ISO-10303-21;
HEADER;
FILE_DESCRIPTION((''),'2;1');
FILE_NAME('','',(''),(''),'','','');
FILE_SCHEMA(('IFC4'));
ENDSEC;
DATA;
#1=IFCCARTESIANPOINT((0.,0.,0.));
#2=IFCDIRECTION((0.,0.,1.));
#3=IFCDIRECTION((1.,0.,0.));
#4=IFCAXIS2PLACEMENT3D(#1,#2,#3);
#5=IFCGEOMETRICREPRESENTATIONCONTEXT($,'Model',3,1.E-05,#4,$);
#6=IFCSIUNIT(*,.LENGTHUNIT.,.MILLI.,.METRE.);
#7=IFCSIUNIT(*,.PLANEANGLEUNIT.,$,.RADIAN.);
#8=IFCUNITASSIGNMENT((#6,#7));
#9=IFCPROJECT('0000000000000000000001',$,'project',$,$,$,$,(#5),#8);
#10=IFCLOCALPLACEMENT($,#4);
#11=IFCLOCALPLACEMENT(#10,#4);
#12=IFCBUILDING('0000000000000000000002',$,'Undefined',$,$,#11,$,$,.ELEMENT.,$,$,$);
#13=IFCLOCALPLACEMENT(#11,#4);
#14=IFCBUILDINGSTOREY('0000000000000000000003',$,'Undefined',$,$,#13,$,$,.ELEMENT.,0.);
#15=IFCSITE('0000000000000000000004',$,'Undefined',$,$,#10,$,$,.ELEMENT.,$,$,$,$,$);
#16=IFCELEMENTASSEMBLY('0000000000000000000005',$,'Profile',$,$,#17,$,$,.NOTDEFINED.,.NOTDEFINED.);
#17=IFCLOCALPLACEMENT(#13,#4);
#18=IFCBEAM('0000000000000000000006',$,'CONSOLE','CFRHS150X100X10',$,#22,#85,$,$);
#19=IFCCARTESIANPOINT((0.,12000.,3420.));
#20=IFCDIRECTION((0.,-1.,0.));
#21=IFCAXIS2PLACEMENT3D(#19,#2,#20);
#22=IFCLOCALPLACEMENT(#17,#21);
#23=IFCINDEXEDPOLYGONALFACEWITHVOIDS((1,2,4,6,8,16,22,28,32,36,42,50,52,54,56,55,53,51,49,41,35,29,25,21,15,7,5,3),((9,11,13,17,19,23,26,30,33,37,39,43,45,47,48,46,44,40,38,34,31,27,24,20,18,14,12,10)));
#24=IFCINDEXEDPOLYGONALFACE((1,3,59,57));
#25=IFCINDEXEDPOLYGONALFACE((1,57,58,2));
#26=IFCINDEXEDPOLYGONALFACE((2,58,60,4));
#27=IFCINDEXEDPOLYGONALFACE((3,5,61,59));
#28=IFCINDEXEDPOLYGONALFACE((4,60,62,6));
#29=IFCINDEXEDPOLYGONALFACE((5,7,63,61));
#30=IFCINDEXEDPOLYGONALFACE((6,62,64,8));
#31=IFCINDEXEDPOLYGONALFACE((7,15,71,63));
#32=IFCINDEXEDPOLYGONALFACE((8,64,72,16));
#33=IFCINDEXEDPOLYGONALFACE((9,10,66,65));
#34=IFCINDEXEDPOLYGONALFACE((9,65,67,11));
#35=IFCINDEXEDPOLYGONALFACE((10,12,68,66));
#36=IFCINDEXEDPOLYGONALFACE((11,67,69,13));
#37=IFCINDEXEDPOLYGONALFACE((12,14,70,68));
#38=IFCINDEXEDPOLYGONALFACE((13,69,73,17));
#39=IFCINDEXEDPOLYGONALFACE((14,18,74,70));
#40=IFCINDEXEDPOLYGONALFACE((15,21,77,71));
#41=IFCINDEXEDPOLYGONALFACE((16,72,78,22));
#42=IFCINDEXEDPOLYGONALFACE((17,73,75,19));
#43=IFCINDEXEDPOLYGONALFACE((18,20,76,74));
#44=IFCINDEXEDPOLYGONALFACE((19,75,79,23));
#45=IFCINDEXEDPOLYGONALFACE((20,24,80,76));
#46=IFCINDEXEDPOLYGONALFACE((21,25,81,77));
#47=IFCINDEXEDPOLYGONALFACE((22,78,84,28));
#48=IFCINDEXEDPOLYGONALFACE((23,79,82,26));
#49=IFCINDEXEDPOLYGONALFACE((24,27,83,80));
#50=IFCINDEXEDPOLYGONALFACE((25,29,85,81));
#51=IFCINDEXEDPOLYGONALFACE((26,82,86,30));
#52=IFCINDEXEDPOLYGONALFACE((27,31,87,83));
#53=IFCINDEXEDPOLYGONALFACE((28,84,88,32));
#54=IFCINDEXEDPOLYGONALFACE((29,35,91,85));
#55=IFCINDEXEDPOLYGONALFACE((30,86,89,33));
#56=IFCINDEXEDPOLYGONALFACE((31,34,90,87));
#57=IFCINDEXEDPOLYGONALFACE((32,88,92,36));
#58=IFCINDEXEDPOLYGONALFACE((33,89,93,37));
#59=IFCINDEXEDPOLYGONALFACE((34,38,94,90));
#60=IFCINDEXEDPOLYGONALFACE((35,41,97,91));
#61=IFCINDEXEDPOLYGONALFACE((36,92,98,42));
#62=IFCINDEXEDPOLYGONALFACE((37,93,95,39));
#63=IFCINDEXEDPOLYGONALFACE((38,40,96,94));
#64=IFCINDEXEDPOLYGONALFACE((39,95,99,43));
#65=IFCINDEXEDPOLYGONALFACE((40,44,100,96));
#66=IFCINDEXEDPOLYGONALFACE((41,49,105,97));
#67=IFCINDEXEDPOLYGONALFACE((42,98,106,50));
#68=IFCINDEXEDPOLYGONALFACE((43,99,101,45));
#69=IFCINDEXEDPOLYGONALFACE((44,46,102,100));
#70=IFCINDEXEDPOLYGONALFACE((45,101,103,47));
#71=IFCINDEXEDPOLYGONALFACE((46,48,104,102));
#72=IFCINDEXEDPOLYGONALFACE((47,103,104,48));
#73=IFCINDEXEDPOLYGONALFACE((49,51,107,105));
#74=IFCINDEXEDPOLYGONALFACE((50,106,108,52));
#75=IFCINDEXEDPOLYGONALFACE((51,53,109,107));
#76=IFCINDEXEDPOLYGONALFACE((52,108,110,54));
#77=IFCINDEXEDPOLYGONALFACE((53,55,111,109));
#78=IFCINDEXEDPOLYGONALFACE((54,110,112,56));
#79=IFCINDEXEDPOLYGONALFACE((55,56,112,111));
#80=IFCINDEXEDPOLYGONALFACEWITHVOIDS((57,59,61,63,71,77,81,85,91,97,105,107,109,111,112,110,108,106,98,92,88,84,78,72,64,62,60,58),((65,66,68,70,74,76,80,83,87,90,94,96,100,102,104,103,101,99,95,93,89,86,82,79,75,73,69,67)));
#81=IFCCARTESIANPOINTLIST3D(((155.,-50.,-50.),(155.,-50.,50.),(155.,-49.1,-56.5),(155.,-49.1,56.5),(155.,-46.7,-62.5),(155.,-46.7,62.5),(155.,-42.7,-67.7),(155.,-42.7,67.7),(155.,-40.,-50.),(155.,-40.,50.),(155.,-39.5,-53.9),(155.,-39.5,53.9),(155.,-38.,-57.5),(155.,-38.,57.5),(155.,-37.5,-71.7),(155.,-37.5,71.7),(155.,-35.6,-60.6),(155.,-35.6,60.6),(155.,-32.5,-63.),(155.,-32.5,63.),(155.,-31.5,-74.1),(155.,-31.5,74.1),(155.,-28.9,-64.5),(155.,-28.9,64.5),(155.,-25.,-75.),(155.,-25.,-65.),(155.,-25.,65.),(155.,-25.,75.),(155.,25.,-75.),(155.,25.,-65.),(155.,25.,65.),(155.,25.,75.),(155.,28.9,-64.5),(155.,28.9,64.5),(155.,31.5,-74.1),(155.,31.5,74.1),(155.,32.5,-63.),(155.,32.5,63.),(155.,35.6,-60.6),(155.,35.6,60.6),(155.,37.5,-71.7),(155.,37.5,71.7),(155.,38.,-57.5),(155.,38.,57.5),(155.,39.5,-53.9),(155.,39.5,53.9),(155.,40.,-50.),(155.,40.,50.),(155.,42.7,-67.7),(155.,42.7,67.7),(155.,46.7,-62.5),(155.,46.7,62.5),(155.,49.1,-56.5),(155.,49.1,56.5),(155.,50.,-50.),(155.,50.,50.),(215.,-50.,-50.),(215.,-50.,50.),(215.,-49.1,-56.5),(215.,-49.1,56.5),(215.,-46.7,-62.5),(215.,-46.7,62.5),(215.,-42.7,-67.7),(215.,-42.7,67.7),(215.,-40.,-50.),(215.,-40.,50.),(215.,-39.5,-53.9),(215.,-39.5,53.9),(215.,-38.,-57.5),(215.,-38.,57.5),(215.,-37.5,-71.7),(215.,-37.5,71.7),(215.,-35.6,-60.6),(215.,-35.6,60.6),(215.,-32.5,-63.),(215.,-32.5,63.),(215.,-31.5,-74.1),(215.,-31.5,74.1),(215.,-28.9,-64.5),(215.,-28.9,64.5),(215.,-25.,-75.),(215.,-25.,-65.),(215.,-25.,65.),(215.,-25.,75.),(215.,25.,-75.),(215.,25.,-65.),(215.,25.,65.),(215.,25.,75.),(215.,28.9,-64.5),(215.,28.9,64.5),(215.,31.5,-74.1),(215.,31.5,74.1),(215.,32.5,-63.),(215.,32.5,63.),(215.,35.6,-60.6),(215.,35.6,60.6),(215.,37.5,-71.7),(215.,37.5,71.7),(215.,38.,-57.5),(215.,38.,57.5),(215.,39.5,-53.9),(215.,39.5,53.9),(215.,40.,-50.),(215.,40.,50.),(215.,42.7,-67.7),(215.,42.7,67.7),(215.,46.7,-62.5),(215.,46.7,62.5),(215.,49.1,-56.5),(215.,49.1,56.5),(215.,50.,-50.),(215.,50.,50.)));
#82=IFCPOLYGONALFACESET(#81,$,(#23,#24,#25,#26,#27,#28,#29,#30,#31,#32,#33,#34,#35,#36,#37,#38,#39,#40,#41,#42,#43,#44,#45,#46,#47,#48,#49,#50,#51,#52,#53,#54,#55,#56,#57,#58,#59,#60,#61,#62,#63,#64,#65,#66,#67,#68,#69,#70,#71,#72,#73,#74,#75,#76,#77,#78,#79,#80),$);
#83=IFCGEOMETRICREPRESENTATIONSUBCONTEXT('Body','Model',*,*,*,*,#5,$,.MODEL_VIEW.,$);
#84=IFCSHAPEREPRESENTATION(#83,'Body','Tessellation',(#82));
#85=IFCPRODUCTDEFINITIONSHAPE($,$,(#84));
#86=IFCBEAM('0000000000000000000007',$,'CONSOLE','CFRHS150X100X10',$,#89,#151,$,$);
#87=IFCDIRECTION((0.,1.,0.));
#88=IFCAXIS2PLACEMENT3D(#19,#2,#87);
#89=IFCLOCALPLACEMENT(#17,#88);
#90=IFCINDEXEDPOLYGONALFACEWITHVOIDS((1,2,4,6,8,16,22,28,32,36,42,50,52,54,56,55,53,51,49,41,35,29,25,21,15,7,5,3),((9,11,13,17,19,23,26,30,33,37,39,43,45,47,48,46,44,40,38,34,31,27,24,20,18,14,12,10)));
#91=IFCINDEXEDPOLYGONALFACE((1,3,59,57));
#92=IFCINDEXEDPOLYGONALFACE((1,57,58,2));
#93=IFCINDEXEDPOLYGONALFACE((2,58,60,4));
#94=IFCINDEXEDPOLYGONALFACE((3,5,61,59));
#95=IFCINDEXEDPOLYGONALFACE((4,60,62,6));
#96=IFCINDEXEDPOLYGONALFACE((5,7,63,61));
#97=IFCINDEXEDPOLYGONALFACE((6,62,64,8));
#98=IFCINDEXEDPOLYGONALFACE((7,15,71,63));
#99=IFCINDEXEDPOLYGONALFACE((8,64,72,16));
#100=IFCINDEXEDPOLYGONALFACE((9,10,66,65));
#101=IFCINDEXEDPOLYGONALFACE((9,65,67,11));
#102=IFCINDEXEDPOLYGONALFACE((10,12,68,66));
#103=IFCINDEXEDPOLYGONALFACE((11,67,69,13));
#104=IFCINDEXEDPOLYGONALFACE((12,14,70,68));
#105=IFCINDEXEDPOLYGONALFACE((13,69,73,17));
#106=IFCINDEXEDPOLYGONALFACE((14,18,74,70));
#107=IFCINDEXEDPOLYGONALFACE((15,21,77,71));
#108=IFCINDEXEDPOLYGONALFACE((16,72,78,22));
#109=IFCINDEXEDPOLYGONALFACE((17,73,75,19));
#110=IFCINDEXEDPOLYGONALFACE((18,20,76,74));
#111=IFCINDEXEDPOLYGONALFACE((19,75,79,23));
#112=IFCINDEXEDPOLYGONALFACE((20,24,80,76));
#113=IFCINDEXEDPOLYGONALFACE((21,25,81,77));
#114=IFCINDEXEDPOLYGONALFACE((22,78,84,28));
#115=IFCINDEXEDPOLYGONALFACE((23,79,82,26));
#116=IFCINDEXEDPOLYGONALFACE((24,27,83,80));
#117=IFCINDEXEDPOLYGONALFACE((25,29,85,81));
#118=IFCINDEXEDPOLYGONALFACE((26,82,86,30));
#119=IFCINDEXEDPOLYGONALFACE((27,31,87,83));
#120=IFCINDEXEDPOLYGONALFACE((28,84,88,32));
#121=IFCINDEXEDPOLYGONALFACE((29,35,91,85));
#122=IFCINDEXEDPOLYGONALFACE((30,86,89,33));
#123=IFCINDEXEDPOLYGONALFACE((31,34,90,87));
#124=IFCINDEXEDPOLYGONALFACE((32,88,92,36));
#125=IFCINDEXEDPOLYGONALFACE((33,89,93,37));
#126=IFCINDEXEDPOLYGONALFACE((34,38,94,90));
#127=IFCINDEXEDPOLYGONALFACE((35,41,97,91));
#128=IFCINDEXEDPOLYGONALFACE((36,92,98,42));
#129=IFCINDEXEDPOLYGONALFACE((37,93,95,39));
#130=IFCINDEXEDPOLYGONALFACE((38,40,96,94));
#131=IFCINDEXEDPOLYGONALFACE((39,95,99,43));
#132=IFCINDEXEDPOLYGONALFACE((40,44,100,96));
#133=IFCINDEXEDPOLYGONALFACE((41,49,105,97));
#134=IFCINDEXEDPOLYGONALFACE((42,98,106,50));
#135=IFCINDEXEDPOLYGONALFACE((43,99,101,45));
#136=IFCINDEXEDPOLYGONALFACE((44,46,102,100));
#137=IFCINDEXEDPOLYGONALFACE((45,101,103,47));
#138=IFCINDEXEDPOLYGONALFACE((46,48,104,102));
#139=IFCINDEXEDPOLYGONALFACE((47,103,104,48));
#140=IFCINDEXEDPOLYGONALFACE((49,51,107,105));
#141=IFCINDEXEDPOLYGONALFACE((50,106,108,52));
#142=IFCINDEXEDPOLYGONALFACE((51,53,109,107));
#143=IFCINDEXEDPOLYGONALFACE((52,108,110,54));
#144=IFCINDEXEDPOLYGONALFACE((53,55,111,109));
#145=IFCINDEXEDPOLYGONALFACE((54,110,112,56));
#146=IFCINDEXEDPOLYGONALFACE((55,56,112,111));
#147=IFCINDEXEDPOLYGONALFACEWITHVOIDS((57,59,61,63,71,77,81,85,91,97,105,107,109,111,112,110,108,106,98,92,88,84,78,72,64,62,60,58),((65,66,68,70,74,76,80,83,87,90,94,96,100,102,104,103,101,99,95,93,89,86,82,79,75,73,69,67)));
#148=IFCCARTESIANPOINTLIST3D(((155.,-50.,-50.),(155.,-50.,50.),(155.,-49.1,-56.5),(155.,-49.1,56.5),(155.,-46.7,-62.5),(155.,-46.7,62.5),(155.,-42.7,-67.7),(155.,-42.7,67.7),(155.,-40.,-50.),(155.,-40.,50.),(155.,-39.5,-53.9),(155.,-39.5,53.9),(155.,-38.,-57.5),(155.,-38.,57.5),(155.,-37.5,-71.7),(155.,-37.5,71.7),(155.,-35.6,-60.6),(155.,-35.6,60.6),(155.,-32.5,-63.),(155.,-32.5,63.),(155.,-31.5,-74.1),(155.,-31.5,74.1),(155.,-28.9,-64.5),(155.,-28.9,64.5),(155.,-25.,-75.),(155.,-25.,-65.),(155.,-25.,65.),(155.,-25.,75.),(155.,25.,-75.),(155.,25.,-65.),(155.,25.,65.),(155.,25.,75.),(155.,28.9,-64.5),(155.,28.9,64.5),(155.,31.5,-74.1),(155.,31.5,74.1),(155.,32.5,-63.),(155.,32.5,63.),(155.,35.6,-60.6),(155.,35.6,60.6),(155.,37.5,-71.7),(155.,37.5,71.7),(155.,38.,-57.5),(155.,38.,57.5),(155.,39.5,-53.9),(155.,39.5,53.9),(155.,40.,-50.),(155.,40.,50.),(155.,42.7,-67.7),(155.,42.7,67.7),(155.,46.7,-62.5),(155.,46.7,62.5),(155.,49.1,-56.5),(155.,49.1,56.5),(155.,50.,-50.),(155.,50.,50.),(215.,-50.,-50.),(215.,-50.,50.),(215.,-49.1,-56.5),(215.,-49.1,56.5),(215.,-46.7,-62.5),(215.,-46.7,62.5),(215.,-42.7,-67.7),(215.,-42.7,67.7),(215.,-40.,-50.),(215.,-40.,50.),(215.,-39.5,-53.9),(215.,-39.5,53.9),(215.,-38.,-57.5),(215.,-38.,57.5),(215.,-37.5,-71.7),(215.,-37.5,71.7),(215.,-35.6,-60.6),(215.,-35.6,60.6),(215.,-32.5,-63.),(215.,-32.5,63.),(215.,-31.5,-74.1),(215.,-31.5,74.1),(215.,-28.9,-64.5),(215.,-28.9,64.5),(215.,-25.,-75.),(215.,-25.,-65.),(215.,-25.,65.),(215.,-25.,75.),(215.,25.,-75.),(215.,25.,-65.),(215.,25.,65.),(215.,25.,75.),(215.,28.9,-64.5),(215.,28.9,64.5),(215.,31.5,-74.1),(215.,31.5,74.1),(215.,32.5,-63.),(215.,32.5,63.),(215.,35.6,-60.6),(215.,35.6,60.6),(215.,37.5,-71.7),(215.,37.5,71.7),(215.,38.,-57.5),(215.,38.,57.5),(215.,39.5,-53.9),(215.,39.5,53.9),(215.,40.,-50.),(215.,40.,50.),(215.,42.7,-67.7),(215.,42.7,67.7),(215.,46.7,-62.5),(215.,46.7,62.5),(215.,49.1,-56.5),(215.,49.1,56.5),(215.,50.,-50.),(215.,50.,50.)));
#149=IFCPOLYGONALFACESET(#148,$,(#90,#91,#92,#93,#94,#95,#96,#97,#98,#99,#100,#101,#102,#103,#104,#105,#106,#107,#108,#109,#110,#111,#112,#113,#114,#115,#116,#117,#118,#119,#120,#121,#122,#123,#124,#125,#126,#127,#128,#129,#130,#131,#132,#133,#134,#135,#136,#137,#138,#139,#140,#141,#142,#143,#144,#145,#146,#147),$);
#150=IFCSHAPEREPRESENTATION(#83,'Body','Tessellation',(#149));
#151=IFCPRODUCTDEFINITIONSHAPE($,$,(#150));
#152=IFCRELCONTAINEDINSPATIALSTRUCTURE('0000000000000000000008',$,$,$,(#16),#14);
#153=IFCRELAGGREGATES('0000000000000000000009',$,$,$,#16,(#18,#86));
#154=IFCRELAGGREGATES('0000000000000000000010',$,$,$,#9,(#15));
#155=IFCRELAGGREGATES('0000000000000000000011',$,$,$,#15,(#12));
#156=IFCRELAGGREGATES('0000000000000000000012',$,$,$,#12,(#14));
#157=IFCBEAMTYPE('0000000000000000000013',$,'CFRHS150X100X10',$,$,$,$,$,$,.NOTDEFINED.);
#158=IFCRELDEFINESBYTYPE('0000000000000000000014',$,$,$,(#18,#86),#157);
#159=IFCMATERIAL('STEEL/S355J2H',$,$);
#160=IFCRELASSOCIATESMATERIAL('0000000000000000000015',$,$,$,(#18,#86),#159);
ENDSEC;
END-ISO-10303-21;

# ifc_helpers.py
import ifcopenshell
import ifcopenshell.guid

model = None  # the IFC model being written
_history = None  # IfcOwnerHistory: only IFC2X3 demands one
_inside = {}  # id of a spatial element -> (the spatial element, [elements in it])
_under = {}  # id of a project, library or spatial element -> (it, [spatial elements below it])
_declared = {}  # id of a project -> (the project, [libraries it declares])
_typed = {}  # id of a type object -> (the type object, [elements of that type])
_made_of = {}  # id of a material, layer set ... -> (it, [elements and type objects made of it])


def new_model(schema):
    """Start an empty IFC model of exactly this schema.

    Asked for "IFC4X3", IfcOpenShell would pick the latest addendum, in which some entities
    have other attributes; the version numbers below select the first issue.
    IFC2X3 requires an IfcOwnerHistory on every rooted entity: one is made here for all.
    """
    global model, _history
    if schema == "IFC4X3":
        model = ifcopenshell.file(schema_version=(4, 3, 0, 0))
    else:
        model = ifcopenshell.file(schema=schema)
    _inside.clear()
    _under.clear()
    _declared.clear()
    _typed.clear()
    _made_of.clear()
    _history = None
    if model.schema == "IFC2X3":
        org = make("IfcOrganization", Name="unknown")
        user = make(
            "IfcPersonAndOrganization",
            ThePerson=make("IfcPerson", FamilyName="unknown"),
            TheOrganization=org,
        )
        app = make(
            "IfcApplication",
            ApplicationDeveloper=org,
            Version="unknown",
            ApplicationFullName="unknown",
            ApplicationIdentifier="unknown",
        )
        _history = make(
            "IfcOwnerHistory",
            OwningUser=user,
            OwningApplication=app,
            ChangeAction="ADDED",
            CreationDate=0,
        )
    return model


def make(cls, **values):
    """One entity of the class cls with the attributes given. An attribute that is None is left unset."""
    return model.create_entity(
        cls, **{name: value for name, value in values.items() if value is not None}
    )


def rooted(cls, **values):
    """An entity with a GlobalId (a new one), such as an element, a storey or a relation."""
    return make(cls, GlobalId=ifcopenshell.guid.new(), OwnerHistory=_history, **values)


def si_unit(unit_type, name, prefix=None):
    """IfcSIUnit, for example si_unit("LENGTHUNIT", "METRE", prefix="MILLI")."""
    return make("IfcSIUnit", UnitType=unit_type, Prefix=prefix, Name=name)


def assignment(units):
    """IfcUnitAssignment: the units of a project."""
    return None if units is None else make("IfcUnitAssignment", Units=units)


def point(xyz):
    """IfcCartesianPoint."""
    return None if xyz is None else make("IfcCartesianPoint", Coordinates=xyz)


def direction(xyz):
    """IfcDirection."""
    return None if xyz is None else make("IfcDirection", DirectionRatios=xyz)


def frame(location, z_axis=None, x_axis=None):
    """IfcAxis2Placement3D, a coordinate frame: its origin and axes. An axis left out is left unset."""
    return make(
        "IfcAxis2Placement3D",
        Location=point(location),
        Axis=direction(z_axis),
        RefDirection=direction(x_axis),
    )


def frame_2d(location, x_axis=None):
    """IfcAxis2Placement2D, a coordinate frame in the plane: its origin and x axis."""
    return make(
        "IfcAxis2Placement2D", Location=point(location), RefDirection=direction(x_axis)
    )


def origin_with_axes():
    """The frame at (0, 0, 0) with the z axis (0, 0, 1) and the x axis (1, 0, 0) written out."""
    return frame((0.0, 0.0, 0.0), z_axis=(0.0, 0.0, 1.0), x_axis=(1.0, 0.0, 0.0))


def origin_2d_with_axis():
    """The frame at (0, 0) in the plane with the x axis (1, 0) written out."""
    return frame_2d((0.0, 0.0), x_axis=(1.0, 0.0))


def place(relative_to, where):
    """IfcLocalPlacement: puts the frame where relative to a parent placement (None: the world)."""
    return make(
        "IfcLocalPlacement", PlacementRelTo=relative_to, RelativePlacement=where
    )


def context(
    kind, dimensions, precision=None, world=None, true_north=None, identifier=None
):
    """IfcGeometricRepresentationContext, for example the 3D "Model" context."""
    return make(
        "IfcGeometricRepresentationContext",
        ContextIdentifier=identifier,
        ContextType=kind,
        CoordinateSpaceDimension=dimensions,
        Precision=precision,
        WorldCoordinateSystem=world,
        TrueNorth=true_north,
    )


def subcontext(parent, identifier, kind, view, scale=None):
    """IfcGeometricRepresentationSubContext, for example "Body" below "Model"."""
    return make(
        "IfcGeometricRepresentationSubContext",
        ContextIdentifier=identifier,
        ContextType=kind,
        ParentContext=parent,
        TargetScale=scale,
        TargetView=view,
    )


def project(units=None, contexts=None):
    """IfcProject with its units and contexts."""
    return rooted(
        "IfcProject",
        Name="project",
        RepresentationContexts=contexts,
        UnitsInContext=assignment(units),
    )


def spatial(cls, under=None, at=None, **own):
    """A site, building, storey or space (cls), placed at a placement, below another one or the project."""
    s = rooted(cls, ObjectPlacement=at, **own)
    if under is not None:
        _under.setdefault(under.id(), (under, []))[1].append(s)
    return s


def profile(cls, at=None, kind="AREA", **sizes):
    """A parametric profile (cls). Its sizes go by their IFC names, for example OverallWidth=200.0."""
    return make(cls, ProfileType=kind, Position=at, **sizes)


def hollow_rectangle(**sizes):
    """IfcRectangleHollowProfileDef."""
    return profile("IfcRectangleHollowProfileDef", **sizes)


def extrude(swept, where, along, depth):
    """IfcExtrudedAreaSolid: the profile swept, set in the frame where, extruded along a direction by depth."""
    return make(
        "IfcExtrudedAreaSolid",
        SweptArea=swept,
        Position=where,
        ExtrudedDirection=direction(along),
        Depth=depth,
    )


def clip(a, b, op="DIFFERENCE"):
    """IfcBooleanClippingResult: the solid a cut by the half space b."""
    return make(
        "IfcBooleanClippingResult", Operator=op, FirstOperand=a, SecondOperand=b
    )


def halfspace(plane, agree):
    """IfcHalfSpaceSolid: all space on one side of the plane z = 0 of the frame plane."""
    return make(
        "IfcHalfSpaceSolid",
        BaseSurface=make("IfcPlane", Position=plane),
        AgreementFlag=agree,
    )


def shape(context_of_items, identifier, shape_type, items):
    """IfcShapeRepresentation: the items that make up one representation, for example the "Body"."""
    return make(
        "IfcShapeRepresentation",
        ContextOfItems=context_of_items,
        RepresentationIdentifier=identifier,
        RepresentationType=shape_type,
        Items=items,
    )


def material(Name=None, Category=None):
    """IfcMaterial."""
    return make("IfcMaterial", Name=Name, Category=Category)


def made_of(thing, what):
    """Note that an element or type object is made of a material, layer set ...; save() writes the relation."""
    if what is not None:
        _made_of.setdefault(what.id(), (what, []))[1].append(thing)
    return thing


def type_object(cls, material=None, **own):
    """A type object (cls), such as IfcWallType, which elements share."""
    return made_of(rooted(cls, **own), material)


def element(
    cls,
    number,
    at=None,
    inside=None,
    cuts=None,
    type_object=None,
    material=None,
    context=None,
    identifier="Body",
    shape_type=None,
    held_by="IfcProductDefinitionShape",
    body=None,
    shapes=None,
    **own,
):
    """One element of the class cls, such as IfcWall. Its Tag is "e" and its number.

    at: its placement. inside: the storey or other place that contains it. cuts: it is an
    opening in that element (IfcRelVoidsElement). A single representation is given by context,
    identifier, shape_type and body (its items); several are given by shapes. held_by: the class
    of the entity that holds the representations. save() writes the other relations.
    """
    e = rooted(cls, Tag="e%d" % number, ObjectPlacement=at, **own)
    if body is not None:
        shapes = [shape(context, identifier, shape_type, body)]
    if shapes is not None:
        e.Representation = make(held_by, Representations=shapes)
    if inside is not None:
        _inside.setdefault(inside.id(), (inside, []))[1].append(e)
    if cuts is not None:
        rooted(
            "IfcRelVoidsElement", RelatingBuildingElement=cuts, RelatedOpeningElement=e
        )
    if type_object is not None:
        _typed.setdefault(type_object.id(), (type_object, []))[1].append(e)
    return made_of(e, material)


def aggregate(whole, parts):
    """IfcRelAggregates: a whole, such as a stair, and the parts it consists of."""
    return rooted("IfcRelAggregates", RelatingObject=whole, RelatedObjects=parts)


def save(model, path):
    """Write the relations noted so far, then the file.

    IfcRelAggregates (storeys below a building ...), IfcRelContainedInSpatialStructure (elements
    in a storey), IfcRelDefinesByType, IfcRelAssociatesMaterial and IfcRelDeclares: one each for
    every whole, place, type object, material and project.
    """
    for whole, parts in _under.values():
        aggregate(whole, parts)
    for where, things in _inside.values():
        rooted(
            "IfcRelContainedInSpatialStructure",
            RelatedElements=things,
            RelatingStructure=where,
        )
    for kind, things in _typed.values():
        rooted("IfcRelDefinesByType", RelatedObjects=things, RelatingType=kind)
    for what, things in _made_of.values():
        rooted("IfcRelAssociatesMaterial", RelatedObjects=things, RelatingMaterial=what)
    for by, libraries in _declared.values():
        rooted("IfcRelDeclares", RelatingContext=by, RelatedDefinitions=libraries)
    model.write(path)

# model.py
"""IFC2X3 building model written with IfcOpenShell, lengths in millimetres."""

from ifc_helpers import new_model, si_unit, frame, origin_with_axes, origin_2d_with_axis, place, context, subcontext, project, spatial, hollow_rectangle, extrude, clip, halfspace, material, type_object, element, aggregate, save


model = new_model("IFC2X3")

# Units and contexts
model_context = context("Model", 3, precision=1e-05, world=origin_with_axes())
body_context = subcontext(model_context, "Body", "Model", "MODEL_VIEW")
ifc_project = project(units=[si_unit("LENGTHUNIT", "METRE", prefix="MILLI"), si_unit("PLANEANGLEUNIT", "RADIAN")], contexts=[model_context])

# Site, building, storey
site_placement = place(None, origin_with_axes())
site = spatial("IfcSite", under=ifc_project, at=site_placement, Name="Undefined", CompositionType="ELEMENT")
building_placement = place(site_placement, origin_with_axes())
building = spatial("IfcBuilding", under=site, at=building_placement, Name="Undefined", CompositionType="ELEMENT")
storey_placement = place(building_placement, origin_with_axes())
storey = spatial("IfcBuildingStorey", under=building, at=storey_placement, Name="Undefined", CompositionType="ELEMENT", Elevation=0.0)

# Element assembly, beams
assembly_1_placement = place(storey_placement, origin_with_axes())
assembly_1 = element("IfcElementAssembly", 1, at=assembly_1_placement, inside=storey, Name="Profile", AssemblyPlace="NOTDEFINED", PredefinedType="NOTDEFINED")
ifc_material_1 = material(Name="STEEL/S355J2H")
beam_type_1 = type_object("IfcBeamType", Name="CFRHS150X100X10", PredefinedType="NOTDEFINED")
beam_1_placement = place(assembly_1_placement, frame((0.0, 12000.0, 3420.0), z_axis=(0.0, 0.0, 1.0), x_axis=(0.0, -1.0, 0.0)))
beam_1 = element("IfcBeam", 2, at=beam_1_placement, type_object=beam_type_1, material=ifc_material_1, Name="CONSOLE", Description="CFRHS150X100X10", context=body_context, shape_type="Clipping", body=[
    clip(extrude(hollow_rectangle(XDim=100.0, YDim=150.0, WallThickness=10.0, InnerFilletRadius=15.0, OuterFilletRadius=25.0, at=origin_2d_with_axis()), frame((215.0, 0.0, 0.0), z_axis=(-1.0, 0.0, 0.0), x_axis=(0.0, -1.0, 0.0)), (0.0, 0.0, 1.0), 215.0), halfspace(frame((155.0, 50.0, -75.0), z_axis=(-1.0, 0.0, 0.0), x_axis=(0.0, 0.0, 1.0)), False)),
])
beam_2_placement = place(assembly_1_placement, frame((0.0, 12000.0, 3420.0), z_axis=(0.0, 0.0, 1.0), x_axis=(0.0, 1.0, 0.0)))
beam_2 = element("IfcBeam", 3, at=beam_2_placement, type_object=beam_type_1, material=ifc_material_1, Name="CONSOLE", Description="CFRHS150X100X10", context=body_context, shape_type="Clipping", body=[
    clip(extrude(hollow_rectangle(XDim=100.0, YDim=150.0, WallThickness=10.0, InnerFilletRadius=15.0, OuterFilletRadius=25.0, at=origin_2d_with_axis()), frame((215.0, 0.0, 0.0), z_axis=(-1.0, 0.0, 0.0), x_axis=(0.0, -1.0, 0.0)), (0.0, 0.0, 1.0), 215.0), halfspace(frame((155.0, 50.0, -75.0), z_axis=(-1.0, 0.0, 0.0), x_axis=(0.0, 0.0, 1.0)), False)),
])

aggregate(assembly_1, [beam_1, beam_2])

save(model, "model.ifc")
